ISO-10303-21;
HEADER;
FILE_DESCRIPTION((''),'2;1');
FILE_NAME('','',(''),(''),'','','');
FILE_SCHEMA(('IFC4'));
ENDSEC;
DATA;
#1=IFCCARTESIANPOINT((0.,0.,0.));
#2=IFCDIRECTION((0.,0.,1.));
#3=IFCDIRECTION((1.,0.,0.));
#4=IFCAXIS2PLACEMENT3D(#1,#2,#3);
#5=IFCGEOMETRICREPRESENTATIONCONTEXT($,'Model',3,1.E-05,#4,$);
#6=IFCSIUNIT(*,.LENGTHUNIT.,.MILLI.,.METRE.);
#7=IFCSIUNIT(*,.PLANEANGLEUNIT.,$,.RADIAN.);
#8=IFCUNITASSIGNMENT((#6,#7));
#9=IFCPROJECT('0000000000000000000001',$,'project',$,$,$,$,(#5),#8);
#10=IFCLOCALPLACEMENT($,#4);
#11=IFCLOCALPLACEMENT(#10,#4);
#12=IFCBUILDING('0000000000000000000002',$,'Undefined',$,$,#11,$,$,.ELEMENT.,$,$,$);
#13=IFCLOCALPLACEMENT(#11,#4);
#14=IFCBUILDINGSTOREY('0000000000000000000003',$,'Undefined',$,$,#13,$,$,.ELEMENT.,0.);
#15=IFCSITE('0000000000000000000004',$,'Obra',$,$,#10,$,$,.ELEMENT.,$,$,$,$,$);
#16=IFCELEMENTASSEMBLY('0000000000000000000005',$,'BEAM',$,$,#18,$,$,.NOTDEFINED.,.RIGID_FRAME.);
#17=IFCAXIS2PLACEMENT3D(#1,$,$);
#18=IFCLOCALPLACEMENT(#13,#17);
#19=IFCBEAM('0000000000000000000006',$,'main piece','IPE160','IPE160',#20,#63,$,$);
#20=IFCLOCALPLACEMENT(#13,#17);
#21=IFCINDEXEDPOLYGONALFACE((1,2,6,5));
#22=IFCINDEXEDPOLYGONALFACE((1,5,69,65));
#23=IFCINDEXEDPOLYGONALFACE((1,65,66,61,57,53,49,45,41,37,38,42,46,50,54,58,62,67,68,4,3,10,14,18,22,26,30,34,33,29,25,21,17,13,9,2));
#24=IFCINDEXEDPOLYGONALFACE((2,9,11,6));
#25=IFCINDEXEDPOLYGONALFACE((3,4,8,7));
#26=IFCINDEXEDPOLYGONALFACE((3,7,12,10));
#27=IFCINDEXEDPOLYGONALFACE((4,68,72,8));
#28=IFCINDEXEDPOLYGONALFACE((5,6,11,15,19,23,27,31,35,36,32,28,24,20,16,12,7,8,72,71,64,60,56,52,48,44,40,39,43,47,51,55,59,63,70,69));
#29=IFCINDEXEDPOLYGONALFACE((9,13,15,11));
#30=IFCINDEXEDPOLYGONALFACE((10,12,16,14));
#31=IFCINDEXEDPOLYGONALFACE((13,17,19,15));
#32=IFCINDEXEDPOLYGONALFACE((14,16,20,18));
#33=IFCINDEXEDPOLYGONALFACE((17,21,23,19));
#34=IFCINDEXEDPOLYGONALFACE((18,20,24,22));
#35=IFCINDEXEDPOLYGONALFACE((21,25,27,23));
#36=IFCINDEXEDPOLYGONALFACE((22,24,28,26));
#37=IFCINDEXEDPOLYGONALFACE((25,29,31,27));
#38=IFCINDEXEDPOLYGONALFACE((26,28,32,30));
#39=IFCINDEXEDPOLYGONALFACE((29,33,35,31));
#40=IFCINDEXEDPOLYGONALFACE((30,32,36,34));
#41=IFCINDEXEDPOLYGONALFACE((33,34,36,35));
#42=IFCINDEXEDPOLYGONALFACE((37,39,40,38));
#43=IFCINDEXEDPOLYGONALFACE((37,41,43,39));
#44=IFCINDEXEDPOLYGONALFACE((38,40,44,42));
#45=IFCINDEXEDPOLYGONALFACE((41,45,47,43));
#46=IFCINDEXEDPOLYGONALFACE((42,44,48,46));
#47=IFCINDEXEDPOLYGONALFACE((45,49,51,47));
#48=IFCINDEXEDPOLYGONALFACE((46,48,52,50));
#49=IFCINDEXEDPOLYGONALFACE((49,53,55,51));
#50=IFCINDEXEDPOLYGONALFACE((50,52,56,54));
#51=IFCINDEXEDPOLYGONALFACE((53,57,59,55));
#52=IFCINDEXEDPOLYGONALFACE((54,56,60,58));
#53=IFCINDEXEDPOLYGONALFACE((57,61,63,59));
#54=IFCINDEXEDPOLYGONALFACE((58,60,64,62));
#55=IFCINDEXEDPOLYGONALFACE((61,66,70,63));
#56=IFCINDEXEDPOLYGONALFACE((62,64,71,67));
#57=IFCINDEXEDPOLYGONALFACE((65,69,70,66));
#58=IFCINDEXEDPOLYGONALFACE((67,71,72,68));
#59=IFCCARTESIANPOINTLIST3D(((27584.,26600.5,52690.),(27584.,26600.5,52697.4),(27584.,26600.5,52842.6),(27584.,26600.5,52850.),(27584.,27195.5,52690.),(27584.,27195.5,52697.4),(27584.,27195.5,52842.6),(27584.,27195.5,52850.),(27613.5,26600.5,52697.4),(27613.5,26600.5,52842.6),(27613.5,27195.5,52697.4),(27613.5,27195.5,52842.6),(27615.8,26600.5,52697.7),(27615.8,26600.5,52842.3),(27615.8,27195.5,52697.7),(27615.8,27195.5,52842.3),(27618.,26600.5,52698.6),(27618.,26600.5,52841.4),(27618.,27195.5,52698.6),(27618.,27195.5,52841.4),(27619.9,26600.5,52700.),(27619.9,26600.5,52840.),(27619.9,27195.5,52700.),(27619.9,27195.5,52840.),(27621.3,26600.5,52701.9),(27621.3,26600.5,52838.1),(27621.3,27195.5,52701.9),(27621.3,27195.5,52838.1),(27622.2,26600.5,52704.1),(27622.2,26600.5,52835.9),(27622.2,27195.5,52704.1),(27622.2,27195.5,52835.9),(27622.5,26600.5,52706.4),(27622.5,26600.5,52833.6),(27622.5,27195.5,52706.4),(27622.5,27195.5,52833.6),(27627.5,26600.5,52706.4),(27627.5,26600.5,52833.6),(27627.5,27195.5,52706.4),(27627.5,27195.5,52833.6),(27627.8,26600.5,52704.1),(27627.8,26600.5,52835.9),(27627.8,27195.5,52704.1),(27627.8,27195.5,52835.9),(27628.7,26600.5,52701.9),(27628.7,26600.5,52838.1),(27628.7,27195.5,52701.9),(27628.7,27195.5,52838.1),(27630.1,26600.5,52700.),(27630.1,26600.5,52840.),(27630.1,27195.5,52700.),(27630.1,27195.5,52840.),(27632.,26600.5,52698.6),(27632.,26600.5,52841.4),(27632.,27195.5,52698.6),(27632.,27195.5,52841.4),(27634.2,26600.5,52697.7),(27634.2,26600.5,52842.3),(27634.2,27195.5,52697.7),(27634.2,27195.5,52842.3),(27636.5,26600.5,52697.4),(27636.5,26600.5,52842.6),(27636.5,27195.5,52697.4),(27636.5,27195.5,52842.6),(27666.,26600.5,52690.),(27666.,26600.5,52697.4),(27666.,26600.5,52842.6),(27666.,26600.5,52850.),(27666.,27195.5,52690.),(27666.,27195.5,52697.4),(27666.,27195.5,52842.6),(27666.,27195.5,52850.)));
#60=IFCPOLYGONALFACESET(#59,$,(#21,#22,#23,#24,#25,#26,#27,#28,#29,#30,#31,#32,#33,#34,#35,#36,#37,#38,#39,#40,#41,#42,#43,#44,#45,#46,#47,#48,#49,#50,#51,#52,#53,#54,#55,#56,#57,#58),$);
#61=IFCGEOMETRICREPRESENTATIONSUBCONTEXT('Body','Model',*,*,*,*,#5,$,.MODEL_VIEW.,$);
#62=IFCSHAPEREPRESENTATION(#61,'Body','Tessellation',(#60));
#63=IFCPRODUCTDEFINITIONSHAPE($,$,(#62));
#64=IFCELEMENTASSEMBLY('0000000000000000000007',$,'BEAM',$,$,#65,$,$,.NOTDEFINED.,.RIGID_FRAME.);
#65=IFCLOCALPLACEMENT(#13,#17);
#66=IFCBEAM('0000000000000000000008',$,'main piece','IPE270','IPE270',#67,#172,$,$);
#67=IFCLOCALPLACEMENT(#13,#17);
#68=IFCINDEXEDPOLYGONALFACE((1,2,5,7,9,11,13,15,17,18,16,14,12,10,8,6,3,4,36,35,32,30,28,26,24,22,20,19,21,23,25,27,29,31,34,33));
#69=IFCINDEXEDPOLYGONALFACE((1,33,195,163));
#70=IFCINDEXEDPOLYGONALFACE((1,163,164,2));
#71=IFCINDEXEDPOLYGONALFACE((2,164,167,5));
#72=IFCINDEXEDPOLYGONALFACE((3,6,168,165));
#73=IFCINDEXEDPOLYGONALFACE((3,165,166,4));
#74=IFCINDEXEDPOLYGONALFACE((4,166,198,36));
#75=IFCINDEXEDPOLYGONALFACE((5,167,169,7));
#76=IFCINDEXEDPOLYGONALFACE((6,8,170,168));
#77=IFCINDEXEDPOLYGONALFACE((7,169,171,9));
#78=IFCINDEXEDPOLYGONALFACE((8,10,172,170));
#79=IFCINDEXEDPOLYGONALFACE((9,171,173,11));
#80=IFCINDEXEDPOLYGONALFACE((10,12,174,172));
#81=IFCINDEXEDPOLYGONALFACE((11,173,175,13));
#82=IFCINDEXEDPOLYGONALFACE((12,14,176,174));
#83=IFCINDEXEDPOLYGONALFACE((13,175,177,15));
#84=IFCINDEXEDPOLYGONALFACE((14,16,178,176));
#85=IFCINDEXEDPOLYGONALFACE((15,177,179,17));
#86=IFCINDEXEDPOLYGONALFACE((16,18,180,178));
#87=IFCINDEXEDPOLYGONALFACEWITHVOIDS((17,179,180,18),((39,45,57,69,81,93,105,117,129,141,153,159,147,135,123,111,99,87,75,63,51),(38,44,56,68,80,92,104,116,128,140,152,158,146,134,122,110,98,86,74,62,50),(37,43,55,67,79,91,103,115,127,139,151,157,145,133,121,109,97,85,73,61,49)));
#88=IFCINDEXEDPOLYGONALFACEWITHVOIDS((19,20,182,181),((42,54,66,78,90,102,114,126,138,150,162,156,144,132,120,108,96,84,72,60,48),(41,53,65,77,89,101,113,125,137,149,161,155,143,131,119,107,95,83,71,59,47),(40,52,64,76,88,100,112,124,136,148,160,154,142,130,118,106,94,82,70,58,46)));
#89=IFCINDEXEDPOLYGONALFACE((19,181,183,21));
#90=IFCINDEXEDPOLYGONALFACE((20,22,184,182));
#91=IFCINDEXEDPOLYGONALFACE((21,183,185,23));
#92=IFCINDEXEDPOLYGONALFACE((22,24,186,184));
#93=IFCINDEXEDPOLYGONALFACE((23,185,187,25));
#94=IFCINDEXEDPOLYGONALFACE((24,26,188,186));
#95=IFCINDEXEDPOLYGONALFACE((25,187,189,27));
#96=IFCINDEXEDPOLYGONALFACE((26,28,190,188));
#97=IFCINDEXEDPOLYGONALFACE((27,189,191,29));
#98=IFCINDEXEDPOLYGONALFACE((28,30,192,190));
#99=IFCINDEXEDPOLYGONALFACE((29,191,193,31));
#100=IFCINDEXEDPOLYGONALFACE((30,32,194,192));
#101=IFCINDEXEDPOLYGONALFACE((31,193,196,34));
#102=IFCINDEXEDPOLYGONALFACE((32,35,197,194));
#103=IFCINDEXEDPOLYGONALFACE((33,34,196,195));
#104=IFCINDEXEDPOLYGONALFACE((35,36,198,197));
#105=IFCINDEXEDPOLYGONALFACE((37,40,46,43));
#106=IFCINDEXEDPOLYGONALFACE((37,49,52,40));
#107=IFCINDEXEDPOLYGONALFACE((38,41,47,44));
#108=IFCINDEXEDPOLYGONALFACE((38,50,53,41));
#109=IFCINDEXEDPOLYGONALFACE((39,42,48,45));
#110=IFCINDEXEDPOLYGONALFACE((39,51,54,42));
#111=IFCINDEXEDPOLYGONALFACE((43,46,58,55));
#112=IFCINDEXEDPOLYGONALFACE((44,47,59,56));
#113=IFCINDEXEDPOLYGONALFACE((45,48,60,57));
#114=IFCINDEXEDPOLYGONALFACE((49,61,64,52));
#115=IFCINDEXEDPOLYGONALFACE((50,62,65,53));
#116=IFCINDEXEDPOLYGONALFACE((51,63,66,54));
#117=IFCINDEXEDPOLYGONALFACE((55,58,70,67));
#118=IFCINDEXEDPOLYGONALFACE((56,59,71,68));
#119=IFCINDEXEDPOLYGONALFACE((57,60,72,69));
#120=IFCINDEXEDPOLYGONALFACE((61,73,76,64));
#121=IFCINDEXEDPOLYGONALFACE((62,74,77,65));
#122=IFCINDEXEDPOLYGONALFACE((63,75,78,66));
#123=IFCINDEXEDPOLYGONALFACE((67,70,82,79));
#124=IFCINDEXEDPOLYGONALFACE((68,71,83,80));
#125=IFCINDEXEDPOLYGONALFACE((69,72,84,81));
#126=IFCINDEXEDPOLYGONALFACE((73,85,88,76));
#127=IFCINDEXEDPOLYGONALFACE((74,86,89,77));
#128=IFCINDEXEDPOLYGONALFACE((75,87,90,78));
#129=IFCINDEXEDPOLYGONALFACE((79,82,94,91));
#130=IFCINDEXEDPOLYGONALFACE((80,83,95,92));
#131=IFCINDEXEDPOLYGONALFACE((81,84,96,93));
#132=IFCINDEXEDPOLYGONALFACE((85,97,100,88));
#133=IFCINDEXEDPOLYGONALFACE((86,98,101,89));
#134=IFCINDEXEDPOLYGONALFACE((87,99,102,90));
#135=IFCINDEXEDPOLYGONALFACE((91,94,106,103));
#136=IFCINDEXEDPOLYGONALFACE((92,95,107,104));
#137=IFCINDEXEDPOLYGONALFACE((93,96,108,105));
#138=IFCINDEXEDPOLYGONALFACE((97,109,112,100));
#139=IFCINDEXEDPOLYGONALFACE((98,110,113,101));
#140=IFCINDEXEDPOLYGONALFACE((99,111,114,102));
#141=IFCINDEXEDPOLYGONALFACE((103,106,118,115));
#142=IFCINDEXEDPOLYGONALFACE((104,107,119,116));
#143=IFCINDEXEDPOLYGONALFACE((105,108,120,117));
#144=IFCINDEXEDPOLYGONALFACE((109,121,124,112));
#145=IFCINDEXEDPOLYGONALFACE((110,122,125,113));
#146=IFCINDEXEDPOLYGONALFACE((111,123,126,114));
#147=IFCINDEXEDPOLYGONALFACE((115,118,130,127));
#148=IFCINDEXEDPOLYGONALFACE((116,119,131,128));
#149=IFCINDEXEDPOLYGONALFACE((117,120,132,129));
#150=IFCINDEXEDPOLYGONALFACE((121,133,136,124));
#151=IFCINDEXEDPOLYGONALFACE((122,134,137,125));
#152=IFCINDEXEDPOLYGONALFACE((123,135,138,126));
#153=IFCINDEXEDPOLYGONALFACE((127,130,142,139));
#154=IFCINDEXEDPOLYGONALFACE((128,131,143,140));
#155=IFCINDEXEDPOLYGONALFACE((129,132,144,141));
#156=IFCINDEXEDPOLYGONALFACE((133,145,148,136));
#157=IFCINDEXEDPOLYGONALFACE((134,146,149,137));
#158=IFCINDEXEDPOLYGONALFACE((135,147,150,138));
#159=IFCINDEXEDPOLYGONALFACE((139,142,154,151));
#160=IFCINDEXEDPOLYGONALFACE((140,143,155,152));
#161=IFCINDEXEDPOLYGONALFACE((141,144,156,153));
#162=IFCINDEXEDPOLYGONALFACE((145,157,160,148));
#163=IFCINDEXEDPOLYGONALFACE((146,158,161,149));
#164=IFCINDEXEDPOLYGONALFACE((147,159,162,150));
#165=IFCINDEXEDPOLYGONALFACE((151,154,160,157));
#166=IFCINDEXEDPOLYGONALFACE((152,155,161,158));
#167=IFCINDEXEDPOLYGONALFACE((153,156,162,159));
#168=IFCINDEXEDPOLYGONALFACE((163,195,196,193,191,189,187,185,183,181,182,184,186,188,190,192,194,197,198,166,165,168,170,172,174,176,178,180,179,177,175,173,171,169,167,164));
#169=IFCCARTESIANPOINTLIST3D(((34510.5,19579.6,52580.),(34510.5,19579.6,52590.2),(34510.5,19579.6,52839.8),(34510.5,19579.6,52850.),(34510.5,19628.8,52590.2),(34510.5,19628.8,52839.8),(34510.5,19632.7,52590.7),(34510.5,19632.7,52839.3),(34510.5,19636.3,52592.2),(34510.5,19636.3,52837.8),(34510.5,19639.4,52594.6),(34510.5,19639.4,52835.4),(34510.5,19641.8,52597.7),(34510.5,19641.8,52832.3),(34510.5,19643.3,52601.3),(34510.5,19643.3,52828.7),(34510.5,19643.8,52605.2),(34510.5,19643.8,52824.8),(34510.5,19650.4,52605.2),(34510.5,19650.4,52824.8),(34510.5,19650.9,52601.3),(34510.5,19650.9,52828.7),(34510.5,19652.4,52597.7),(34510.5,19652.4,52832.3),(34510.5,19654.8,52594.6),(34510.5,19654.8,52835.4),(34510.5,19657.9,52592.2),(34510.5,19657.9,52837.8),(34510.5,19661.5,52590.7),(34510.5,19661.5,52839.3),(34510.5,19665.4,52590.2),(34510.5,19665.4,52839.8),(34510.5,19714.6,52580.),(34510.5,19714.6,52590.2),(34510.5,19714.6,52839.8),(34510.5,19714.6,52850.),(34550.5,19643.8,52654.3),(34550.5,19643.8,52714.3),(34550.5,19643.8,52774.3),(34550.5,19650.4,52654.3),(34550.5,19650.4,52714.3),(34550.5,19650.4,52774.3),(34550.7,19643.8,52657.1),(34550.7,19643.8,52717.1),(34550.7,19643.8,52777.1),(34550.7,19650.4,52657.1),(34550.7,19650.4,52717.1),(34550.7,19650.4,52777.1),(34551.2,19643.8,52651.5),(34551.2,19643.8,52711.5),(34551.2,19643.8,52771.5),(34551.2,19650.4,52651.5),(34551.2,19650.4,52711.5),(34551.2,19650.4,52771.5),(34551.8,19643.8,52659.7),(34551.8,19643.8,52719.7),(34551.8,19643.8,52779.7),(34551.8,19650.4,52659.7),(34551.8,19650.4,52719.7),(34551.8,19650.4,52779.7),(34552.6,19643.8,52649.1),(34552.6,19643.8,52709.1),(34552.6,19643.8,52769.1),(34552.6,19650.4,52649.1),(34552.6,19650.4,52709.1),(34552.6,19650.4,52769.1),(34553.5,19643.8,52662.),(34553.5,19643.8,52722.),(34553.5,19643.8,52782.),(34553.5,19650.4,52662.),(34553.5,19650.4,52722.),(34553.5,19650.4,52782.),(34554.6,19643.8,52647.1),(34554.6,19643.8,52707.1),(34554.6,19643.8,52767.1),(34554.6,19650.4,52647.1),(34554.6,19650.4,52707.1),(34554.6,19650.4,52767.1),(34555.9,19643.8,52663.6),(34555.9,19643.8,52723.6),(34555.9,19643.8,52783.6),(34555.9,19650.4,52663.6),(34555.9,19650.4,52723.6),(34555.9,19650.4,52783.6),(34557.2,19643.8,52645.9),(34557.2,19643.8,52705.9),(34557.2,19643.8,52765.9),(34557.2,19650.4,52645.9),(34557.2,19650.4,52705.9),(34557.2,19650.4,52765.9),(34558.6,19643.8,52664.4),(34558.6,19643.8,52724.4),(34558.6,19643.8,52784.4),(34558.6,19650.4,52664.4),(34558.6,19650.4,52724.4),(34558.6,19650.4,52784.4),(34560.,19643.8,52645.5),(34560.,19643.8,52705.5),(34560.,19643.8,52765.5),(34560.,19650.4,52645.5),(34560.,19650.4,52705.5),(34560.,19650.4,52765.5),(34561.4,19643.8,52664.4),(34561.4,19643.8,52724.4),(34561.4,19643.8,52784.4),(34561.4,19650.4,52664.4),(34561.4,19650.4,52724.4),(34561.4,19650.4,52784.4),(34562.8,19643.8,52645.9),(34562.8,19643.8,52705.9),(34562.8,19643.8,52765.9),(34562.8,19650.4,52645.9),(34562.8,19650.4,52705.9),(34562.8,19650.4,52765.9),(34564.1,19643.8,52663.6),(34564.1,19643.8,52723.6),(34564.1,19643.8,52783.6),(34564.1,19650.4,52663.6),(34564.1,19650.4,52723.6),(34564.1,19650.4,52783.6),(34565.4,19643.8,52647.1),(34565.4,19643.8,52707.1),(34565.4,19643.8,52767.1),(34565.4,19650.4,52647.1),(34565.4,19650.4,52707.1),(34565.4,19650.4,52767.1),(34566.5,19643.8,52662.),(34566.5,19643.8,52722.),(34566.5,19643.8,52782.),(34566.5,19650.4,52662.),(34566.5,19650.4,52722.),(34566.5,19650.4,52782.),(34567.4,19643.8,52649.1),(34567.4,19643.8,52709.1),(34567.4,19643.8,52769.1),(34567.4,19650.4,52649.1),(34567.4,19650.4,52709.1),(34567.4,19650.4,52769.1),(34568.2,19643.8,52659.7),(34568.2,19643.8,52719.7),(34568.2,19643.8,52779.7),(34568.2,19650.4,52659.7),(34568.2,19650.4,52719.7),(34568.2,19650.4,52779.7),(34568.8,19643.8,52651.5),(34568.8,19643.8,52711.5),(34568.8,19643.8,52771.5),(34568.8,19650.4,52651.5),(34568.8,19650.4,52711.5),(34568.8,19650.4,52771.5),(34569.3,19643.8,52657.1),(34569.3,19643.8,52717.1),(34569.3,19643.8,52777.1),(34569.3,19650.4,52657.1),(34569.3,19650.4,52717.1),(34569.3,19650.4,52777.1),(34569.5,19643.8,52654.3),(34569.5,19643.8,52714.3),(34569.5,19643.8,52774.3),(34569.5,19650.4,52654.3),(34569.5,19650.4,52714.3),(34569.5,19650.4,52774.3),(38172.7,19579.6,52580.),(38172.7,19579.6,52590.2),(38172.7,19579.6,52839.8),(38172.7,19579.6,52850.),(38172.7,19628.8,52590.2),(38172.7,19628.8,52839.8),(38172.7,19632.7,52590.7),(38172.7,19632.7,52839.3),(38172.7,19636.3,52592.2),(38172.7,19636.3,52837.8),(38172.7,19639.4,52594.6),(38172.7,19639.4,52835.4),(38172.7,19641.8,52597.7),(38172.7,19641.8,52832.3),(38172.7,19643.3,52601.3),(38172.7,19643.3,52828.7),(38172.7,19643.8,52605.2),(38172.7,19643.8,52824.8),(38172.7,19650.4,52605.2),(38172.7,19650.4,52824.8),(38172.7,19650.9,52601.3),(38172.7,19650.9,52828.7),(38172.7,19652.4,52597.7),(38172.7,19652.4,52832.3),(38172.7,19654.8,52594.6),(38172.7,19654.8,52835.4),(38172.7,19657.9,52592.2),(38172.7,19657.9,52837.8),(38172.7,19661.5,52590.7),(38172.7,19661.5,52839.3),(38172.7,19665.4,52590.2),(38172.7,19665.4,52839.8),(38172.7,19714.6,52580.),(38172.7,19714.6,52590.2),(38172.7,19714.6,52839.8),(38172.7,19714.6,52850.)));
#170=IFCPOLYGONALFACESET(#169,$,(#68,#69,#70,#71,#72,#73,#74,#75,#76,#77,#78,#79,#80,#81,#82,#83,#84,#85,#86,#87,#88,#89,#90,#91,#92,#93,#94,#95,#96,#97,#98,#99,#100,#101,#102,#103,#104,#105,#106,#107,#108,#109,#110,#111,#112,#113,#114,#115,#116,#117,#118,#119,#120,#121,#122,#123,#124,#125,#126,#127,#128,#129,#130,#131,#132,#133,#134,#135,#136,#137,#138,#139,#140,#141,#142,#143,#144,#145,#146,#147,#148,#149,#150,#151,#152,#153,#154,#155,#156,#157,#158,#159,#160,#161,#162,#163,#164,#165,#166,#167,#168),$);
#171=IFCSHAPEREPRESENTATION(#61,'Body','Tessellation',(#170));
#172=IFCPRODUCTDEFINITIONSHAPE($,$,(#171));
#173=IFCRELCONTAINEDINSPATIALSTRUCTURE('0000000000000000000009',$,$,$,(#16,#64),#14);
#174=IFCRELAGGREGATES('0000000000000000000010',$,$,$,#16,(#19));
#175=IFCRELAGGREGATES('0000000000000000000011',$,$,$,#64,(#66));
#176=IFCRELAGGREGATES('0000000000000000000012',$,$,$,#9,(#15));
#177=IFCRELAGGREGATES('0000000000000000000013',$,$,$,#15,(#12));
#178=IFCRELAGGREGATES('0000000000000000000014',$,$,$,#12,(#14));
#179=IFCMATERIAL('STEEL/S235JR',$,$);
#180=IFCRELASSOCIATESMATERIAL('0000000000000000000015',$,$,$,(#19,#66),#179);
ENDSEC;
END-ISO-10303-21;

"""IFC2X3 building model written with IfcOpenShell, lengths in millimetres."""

from ifc_helpers import new_model, si_unit, frame, origin_with_axes, origin_2d_with_axis, place, context, subcontext, project, spatial, circle, i_section, extrude, clip, halfspace, source, transform, mapped, material, element, aggregate, save


model = new_model("IFC2X3")

# Units and contexts
model_context = context("Model", 3, precision=1e-05, world=origin_with_axes())
body_context = subcontext(model_context, "Body", "Model", "MODEL_VIEW")
ifc_project = project(units=[si_unit("LENGTHUNIT", "METRE", prefix="MILLI"), si_unit("PLANEANGLEUNIT", "RADIAN")], contexts=[model_context])

# Site, building, storey
site_placement = place(None, origin_with_axes())
site = spatial("IfcSite", under=ifc_project, at=site_placement, Name="Obra", CompositionType="ELEMENT")
building_placement = place(site_placement, origin_with_axes())
building = spatial("IfcBuilding", under=site, at=building_placement, Name="Undefined", CompositionType="ELEMENT")
storey_placement = place(building_placement, origin_with_axes())
storey = spatial("IfcBuildingStorey", under=building, at=storey_placement, Name="Undefined", CompositionType="ELEMENT", Elevation=0.0)

# Shared definitions
ifc_material_1 = material(Name="STEEL/S235JR")

# Element assembly, beam
assembly_1_placement = place(storey_placement, origin_with_axes())
assembly_1 = element("IfcElementAssembly", 1, at=assembly_1_placement, inside=storey, Name="BEAM", AssemblyPlace="NOTDEFINED", PredefinedType="RIGID_FRAME")
beam_1_placement = place(assembly_1_placement, frame((27625.0, 26600.5, 52770.0), z_axis=(0.0, 0.0, 1.0), x_axis=(0.0, 1.0, 0.0)))
beam_1 = element("IfcBeam", 2, at=beam_1_placement, material=ifc_material_1, Name="main piece", Description="IPE160", ObjectType="IPE160", context=body_context, shape_type="SweptSolid", body=[
    extrude(i_section(OverallWidth=82.0, OverallDepth=160.0, WebThickness=5.0, FlangeThickness=7.4, FilletRadius=9.0, at=origin_2d_with_axis()), frame((595.0, 0.0, 0.0), z_axis=(-1.0, 0.0, 0.0), x_axis=(0.0, -1.0, 0.0)), (0.0, 0.0, 1.0), 595.0),
])
aggregate(assembly_1, [beam_1])

# Element assembly, beam, opening
assembly_2_placement = place(storey_placement, origin_with_axes())
assembly_2 = element("IfcElementAssembly", 3, at=assembly_2_placement, inside=storey, Name="BEAM", AssemblyPlace="NOTDEFINED", PredefinedType="RIGID_FRAME")
beam_2_placement = place(assembly_2_placement, frame((34272.7, 19647.1, 52715.0), z_axis=(0.0, 0.0, 1.0), x_axis=(1.0, 0.0, 0.0)))
beam_2 = element("IfcBeam", 4, at=beam_2_placement, material=ifc_material_1, Name="main piece", Description="IPE270", ObjectType="IPE270", context=body_context, shape_type="Clipping", body=[
    clip(extrude(i_section(OverallWidth=135.0, OverallDepth=270.0, WebThickness=6.6, FlangeThickness=10.2, FilletRadius=15.0, at=origin_2d_with_axis()), frame((3900.0, 0.0, 0.0), z_axis=(-1.0, 0.0, 0.0), x_axis=(0.0, -1.0, 0.0)), (0.0, 0.0, 1.0), 3900.0), halfspace(frame((237.8, 60.0, -120.0), z_axis=(-1.0, -0.000019, 0.0), x_axis=(0.0, 0.0, 1.0)), False)),
])
shared_shape_1 = source(origin_with_axes(), body_context, "Body", "SweptSolid", [
    extrude(circle(Radius=9.5, at=origin_2d_with_axis()), frame((0.0, -3.4, 0.0), z_axis=(0.0, 1.0, 0.0), x_axis=(1.0, 0.0, 0.0)), (0.0, 0.0, 1.0), 6.8),
])
opening_1_placement = place(assembly_2_placement, frame((34510.0, 19647.1, 52835.0), z_axis=(1.0, 0.0, 0.0), x_axis=(0.0, 0.0, -1.0)))
element("IfcOpeningElement", 5, at=opening_1_placement, cuts=beam_2, ObjectType="Opening", context=body_context, shape_type="MappedRepresentation", body=[
    mapped(shared_shape_1, transform((60.0, 0.0, 50.0))),
    mapped(shared_shape_1, transform((120.0, 0.0, 50.0))),
    mapped(shared_shape_1, transform((180.0, 0.0, 50.0))),
])
aggregate(assembly_2, [beam_2])

save(model, "model.ifc")
